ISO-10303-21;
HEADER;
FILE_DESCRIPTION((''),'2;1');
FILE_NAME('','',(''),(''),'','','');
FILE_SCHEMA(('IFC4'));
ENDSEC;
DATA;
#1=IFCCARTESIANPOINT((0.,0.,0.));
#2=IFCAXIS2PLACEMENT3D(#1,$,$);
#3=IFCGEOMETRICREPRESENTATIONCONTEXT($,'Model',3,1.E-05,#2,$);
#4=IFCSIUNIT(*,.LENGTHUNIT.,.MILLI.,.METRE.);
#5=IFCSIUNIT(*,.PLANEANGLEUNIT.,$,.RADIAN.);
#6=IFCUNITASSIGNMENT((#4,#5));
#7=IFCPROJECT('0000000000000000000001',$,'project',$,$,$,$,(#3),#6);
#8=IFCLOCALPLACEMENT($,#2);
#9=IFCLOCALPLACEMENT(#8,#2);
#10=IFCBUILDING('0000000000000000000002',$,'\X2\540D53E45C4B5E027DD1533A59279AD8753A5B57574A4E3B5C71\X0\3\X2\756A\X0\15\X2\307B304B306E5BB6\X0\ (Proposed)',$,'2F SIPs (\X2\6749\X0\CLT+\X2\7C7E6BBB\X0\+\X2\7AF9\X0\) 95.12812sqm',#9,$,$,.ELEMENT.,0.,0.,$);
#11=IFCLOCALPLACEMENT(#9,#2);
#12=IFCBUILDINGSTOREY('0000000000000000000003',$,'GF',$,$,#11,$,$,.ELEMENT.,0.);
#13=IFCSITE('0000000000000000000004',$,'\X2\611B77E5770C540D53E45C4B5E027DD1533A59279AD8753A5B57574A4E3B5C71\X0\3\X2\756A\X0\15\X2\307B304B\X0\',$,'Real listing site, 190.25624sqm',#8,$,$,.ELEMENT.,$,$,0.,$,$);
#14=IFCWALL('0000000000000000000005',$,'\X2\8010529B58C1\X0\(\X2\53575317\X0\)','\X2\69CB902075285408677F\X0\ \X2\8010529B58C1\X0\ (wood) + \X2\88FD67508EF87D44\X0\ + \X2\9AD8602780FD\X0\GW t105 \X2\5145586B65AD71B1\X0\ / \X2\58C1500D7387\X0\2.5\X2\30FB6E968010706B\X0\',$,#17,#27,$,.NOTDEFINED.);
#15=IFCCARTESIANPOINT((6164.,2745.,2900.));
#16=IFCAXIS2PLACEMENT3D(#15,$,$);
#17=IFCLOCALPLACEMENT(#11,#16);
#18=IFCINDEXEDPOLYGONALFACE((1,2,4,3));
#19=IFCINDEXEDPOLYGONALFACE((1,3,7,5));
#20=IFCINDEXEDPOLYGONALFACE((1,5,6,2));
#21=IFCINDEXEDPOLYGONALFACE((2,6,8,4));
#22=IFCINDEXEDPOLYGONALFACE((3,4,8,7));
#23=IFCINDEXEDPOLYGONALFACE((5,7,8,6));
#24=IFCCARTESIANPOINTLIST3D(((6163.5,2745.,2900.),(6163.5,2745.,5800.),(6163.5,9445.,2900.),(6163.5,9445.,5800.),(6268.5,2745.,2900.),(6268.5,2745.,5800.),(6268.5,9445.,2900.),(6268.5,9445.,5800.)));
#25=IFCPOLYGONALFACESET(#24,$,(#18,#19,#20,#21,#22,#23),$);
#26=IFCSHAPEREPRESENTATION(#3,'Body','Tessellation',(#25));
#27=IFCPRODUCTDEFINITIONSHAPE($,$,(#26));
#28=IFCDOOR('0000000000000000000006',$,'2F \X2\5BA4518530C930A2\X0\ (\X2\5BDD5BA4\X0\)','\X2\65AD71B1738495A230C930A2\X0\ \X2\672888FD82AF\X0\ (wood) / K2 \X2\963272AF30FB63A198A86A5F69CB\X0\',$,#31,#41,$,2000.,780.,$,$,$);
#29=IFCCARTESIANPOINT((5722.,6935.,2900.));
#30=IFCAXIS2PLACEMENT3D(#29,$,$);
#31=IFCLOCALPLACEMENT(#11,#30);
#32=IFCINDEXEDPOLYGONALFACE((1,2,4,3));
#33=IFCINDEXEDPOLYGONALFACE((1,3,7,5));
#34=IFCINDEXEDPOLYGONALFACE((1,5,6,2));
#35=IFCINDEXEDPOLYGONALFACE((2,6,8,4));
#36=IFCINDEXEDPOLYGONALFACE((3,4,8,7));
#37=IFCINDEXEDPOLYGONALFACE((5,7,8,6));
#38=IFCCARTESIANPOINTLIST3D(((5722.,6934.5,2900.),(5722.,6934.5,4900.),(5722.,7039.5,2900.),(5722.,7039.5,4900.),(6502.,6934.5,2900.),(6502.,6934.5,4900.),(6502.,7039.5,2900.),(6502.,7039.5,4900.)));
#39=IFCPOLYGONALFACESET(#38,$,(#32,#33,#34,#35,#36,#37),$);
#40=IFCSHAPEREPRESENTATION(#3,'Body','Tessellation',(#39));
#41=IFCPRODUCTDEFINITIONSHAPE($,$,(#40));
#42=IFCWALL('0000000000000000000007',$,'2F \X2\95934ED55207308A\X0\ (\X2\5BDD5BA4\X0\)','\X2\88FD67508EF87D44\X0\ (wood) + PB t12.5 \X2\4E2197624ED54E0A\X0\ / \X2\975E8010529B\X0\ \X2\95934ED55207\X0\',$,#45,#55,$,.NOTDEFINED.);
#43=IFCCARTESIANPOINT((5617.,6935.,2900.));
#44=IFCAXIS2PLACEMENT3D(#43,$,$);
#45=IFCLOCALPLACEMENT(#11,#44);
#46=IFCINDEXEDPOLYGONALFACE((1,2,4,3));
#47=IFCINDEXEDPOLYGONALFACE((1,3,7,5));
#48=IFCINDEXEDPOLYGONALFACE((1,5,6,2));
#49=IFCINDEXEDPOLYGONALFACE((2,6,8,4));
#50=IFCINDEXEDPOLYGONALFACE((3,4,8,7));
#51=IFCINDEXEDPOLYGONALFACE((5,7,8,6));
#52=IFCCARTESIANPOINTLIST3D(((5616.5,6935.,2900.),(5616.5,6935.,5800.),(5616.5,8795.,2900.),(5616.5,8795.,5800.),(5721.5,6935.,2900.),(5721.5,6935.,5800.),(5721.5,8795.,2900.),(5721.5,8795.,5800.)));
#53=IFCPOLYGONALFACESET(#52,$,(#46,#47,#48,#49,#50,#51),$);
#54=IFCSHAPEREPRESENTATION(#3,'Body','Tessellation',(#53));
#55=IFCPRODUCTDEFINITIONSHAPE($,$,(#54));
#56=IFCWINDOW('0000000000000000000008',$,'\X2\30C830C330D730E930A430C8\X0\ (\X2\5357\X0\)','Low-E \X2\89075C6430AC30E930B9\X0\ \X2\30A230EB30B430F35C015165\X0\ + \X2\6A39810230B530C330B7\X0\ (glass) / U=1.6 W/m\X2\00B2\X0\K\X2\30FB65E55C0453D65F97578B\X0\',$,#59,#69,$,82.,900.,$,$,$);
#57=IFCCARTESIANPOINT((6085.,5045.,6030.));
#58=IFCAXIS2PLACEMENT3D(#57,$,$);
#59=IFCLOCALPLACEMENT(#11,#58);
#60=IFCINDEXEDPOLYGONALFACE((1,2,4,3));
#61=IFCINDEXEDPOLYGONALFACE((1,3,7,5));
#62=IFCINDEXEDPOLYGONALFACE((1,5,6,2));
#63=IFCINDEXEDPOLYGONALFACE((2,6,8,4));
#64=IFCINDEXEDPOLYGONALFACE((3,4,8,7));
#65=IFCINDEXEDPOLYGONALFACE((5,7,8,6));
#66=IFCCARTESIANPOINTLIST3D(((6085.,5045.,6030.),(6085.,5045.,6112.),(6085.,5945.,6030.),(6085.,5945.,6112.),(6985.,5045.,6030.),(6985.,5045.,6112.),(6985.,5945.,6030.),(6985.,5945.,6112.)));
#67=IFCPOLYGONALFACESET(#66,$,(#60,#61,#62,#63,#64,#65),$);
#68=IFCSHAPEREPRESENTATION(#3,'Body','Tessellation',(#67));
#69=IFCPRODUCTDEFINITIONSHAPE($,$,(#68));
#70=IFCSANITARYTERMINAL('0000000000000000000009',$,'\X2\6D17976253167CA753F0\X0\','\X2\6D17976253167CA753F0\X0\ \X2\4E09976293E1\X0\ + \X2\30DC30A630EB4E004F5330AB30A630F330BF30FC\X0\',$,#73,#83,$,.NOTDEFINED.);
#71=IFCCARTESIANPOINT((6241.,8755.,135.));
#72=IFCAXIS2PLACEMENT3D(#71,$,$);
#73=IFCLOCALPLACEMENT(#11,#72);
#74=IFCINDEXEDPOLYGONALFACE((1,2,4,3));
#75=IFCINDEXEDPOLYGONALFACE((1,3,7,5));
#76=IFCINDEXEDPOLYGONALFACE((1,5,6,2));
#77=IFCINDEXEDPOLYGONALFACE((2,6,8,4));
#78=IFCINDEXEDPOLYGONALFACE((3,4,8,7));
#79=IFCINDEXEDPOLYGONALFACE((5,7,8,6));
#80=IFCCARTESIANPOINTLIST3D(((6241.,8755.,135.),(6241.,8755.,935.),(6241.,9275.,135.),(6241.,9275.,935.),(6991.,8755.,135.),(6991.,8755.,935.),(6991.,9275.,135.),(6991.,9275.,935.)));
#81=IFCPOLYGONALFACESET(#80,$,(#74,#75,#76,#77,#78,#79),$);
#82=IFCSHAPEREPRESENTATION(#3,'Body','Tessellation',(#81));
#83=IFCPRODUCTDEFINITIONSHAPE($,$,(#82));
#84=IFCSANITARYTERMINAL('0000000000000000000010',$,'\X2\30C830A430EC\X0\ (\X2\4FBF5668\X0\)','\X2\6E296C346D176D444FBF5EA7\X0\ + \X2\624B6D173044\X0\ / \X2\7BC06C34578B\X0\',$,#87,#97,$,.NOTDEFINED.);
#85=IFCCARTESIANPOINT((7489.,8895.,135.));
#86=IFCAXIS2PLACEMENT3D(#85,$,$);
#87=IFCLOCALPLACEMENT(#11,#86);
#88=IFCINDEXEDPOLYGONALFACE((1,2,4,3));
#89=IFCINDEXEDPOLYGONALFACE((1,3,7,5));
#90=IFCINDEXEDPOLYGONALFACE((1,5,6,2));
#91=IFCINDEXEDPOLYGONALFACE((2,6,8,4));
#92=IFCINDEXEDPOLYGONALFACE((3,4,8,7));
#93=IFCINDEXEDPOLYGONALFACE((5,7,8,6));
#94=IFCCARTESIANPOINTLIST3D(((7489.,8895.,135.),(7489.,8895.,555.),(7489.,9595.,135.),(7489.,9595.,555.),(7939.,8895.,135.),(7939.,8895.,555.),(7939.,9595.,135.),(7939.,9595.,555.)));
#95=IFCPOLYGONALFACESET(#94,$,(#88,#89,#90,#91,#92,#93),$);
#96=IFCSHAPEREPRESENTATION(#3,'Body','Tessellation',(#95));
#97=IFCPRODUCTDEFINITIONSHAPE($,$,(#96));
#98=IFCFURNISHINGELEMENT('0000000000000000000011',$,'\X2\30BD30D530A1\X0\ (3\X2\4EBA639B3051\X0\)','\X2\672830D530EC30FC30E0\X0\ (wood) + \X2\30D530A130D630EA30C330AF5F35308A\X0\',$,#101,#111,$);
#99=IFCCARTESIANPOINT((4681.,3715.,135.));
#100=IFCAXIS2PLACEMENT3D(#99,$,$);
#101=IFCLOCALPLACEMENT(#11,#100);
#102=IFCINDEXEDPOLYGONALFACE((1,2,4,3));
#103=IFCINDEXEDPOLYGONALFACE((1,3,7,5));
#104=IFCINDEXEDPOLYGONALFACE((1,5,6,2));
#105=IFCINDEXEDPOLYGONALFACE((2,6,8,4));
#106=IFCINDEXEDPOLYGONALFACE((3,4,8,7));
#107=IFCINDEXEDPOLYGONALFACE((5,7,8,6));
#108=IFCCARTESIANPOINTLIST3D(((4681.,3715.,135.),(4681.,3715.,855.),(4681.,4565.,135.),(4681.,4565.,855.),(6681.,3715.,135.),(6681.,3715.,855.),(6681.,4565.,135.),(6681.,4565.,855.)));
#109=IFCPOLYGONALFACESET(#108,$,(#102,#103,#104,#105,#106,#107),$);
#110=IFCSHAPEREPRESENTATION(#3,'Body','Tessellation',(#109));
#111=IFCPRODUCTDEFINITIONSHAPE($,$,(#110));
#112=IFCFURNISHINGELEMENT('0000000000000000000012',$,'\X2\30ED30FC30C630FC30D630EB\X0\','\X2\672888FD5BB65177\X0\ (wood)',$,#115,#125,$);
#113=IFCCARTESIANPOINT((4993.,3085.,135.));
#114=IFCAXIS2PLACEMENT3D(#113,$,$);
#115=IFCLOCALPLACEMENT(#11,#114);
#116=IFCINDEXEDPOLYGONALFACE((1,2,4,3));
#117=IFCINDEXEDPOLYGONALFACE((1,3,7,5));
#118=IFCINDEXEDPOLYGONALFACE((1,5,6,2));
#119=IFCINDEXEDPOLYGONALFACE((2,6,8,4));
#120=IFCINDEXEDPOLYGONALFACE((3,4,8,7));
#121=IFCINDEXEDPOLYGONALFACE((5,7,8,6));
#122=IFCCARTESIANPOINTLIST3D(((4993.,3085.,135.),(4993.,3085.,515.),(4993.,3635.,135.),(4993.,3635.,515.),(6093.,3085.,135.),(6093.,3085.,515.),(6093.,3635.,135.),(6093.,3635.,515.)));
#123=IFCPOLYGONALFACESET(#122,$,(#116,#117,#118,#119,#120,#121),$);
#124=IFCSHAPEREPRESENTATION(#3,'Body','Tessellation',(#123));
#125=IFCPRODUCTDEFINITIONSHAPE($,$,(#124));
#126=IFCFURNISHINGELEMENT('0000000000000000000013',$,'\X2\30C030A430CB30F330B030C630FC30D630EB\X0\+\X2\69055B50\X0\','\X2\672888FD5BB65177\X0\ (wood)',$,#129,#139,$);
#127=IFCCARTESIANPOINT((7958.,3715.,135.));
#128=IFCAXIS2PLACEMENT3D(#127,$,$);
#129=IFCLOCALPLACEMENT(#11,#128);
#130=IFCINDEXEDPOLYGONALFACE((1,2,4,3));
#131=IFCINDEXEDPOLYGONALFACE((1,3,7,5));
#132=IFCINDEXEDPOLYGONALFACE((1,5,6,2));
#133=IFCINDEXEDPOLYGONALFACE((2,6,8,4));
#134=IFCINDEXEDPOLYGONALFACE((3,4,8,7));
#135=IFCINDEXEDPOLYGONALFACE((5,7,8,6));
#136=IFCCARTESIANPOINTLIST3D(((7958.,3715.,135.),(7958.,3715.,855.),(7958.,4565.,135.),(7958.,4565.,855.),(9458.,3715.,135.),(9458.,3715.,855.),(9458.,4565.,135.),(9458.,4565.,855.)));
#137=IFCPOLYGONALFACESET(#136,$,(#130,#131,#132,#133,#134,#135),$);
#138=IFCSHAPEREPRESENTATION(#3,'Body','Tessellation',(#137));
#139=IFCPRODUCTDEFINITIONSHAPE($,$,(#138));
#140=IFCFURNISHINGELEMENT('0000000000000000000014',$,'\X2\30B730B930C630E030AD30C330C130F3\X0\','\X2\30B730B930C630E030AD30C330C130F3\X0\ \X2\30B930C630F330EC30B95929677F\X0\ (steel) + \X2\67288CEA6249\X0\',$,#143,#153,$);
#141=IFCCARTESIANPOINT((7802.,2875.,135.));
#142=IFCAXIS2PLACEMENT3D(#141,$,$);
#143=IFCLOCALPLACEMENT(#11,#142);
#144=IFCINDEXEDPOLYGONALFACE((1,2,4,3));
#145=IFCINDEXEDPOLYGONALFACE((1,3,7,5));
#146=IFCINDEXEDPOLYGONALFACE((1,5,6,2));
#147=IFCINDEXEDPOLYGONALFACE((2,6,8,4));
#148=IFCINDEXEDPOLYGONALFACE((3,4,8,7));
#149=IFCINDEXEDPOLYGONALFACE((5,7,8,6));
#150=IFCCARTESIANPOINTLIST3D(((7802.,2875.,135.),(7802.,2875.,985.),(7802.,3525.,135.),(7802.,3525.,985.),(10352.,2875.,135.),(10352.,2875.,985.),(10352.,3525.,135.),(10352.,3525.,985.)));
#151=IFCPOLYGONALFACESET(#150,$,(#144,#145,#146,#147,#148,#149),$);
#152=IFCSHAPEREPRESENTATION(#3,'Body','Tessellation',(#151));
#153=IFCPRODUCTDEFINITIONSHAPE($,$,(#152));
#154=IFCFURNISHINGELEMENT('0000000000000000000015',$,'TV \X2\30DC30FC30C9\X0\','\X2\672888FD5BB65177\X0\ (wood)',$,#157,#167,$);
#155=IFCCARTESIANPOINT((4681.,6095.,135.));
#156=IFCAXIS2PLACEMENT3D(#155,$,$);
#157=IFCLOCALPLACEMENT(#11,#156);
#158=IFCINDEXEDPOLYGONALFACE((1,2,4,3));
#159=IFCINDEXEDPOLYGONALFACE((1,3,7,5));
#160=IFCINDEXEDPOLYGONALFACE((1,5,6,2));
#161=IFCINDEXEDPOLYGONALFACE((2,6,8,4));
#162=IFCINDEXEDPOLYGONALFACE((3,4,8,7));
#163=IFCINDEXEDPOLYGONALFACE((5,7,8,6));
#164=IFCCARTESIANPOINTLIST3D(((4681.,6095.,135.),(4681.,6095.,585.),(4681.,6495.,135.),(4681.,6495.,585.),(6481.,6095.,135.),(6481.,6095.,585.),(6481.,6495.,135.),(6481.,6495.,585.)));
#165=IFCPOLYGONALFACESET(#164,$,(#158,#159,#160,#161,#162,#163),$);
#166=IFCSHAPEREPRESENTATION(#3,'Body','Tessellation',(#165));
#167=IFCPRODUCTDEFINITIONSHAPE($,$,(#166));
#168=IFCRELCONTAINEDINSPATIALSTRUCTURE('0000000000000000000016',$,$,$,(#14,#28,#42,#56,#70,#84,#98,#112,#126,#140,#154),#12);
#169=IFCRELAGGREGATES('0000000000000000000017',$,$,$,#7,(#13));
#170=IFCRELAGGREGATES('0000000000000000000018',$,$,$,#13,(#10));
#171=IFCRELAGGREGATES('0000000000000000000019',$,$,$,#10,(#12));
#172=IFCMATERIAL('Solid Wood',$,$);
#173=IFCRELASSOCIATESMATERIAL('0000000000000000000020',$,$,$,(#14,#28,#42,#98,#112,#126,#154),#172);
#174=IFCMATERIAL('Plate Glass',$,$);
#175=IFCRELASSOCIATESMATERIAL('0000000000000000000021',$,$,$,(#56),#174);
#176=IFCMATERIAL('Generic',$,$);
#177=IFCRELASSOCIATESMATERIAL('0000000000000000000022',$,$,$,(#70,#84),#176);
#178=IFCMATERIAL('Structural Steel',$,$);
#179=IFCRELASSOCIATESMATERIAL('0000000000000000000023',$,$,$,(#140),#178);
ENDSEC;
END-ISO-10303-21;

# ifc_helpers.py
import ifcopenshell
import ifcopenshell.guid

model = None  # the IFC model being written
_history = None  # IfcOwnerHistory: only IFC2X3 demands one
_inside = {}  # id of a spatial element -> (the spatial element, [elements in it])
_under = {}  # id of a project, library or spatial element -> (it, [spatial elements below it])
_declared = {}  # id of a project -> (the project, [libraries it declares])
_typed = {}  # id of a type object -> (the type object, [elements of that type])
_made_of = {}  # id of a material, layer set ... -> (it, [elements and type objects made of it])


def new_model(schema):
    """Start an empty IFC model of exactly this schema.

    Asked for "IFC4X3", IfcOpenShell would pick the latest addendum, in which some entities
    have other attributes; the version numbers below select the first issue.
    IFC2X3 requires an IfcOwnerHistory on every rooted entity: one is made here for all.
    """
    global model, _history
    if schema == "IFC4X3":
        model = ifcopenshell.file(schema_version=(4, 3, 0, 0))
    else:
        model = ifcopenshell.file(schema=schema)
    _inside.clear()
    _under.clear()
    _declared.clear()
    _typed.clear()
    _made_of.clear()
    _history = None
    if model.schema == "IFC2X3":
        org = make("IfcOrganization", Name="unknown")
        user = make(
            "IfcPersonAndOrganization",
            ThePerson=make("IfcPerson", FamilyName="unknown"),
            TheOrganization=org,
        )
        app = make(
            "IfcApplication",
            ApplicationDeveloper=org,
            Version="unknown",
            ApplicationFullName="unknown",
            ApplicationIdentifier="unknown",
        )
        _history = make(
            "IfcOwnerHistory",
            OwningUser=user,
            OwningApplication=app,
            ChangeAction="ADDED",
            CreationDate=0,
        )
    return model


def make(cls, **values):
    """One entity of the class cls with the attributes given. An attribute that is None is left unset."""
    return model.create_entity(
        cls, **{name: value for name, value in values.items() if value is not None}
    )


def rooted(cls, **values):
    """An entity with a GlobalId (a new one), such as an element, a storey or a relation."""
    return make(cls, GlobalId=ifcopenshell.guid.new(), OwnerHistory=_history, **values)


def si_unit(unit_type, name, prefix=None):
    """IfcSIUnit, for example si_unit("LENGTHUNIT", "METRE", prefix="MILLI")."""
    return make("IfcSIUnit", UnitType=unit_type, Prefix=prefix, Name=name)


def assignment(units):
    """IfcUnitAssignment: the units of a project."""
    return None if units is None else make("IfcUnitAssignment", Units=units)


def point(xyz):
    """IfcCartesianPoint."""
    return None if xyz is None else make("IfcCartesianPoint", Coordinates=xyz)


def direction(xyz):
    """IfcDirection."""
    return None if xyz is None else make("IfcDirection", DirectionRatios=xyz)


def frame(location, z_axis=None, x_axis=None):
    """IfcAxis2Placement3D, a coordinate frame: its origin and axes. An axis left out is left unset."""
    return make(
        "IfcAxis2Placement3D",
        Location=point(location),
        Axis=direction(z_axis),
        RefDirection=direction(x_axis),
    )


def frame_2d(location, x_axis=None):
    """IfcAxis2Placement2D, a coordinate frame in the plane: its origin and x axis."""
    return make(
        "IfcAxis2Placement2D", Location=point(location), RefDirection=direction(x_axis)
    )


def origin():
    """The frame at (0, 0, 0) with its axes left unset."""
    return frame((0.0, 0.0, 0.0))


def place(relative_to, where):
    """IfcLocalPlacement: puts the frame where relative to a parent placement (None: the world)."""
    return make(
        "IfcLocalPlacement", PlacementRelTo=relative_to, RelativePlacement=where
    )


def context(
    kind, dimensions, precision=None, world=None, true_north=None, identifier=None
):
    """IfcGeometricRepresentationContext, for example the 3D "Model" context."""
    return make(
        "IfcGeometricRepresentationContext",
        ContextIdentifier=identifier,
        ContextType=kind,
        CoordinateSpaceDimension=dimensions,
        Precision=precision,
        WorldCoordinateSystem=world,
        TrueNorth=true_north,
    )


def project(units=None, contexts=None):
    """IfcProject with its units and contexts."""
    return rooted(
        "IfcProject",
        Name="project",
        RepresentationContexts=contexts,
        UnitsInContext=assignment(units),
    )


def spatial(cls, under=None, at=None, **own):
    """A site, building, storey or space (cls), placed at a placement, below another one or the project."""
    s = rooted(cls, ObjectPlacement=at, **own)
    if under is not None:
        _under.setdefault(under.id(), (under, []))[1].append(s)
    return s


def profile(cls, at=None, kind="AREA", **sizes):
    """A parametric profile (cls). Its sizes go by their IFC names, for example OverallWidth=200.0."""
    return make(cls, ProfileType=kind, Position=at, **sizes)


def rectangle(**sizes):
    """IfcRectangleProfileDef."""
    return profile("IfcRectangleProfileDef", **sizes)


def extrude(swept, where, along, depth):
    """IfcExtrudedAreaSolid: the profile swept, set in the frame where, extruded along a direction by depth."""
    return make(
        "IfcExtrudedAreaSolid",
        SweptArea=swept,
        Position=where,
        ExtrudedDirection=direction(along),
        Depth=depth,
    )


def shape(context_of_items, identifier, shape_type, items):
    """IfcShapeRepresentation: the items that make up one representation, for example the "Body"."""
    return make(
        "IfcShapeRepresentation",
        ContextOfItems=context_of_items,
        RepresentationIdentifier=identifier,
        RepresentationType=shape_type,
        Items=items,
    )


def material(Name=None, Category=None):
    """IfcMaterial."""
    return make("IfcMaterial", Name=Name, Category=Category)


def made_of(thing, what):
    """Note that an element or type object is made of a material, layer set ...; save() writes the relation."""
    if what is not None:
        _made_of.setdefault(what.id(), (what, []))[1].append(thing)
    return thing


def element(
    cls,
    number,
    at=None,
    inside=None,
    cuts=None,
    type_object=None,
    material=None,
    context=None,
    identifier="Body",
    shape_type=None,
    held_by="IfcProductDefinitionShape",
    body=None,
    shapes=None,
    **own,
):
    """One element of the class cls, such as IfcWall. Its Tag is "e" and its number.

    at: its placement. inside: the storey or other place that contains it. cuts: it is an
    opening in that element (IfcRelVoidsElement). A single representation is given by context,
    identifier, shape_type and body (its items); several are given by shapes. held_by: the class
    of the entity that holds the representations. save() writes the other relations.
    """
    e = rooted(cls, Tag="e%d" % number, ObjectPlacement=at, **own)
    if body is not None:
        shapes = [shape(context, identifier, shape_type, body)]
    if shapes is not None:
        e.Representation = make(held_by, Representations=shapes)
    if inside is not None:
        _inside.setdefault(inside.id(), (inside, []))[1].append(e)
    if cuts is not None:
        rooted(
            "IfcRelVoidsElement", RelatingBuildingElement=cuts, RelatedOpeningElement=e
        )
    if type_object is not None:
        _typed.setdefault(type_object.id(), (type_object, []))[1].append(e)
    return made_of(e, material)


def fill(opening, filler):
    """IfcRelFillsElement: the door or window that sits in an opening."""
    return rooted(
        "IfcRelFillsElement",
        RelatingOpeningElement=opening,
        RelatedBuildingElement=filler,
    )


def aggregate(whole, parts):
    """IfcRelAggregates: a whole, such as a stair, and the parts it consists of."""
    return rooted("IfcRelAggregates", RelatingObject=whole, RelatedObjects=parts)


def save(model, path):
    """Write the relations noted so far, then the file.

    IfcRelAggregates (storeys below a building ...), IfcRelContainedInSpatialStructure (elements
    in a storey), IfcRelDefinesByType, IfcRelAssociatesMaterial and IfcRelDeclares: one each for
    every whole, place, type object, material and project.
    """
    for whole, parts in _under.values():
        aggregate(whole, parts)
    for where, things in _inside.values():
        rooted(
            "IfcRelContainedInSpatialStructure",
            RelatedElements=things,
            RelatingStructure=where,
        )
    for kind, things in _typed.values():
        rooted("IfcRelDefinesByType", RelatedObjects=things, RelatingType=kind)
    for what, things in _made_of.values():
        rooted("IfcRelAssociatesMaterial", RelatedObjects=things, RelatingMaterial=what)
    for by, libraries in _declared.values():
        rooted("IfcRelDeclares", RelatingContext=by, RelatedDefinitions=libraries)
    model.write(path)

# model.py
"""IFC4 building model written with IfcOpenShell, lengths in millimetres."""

from ifc_helpers import new_model, si_unit, frame, frame_2d, origin, place, context, project, spatial, rectangle, extrude, material, element, fill, save


model = new_model("IFC4")

# Units and contexts
model_context = context("Model", 3, precision=1e-05, world=origin())
ifc_project = project(units=[si_unit("LENGTHUNIT", "METRE", prefix="MILLI"), si_unit("PLANEANGLEUNIT", "RADIAN")], contexts=[model_context])

# Site, building, storey
site_placement = place(None, origin())
site = spatial("IfcSite", under=ifc_project, at=site_placement, Name="愛知県名古屋市緑区大高町字坊主山3番15ほか", ObjectType="Real listing site, 190.25624sqm", CompositionType="ELEMENT", RefElevation=0.0)
building_placement = place(site_placement, origin())
building = spatial("IfcBuilding", under=site, at=building_placement, Name="名古屋市緑区大高町字坊主山3番15ほかの家 (Proposed)", ObjectType="2F SIPs (杉CLT+籾殻+竹) 95.12812sqm", CompositionType="ELEMENT", ElevationOfRefHeight=0.0, ElevationOfTerrain=0.0)
storey_placement = place(building_placement, origin())
storey = spatial("IfcBuildingStorey", under=building, at=storey_placement, Name="GF", CompositionType="ELEMENT", Elevation=0.0)

# Shared definitions
ifc_material_1 = material(Name="Solid Wood")

# Wall, opening, door
wall_1_placement = place(storey_placement, frame((6164.0, 2745.0, 2900.0)))
wall_1 = element("IfcWall", 1, at=wall_1_placement, inside=storey, material=ifc_material_1, Name="耐力壁(南北)", Description="構造用合板 耐力壁 (wood) + 製材軸組 + 高性能GW t105 充填断熱 / 壁倍率2.5・準耐火", PredefinedType="NOTDEFINED", context=model_context, shape_type="SweptSolid", body=[
    extrude(rectangle(XDim=105.0, YDim=6700.0, at=frame_2d((52.0, 3350.0))), frame((6164.0, 2745.0, 2900.0)), (0.0, 0.0, 1.0), 2900.0),
])
opening_1_placement = place(storey_placement, frame((5722.0, 6935.0, 2900.0)))
opening_1 = element("IfcOpeningElement", 2, at=opening_1_placement, cuts=wall_1, PredefinedType="NOTDEFINED", context=model_context, shape_type="SweptSolid", body=[
    extrude(rectangle(XDim=780.0, YDim=105.0, at=frame_2d((390.0, 52.0))), frame((5722.0, 6935.0, 2900.0)), (0.0, 0.0, 1.0), 2000.0),
])
door_1_placement = place(storey_placement, frame((5722.0, 6935.0, 2900.0)))
door_1 = element("IfcDoor", 3, at=door_1_placement, inside=storey, material=ifc_material_1, Name="2F 室内ドア (寝室)", Description="断熱玄関ドア 木製芯 (wood) / K2 防犯・採風機構", OverallHeight=2000.0, OverallWidth=780.0, context=model_context, shape_type="SweptSolid", body=[
    extrude(rectangle(XDim=780.0, YDim=105.0, at=frame_2d((390.0, 52.0))), frame((5722.0, 6935.0, 2900.0)), (0.0, 0.0, 1.0), 2000.0),
])
fill(opening_1, door_1)

# Wall
wall_2_placement = place(storey_placement, frame((5617.0, 6935.0, 2900.0)))
element("IfcWall", 4, at=wall_2_placement, inside=storey, material=ifc_material_1, Name="2F 間仕切り (寝室)", Description="製材軸組 (wood) + PB t12.5 両面仕上 / 非耐力 間仕切", PredefinedType="NOTDEFINED", context=model_context, shape_type="SweptSolid", body=[
    extrude(rectangle(XDim=105.0, YDim=1860.0, at=frame_2d((52.0, 930.0))), frame((5617.0, 6935.0, 2900.0)), (0.0, 0.0, 1.0), 2900.0),
])

# Window
ifc_material_2 = material(Name="Plate Glass")
window_placement = place(storey_placement, frame((6085.0, 5045.0, 6030.0)))
element("IfcWindow", 5, at=window_placement, inside=storey, material=ifc_material_2, Name="トップライト (南)", Description="Low-E 複層ガラス アルゴン封入 + 樹脂サッシ (glass) / U=1.6 W/m²K・日射取得型", OverallHeight=82.0, OverallWidth=900.0, context=model_context, shape_type="SweptSolid", body=[
    extrude(rectangle(XDim=900.0, YDim=900.0, at=frame_2d((450.0, 450.0))), frame((6085.0, 5045.0, 6030.0)), (0.0, 0.0, 1.0), 82.0),
])

# Sanitary terminals
ifc_material_3 = material(Name="Generic")
sanitary_terminal_1_placement = place(storey_placement, frame((6241.0, 8755.0, 135.0)))
element("IfcSanitaryTerminal", 6, at=sanitary_terminal_1_placement, inside=storey, material=ifc_material_3, Name="洗面化粧台", Description="洗面化粧台 三面鏡 + ボウル一体カウンター", PredefinedType="NOTDEFINED", context=model_context, shape_type="SweptSolid", body=[
    extrude(rectangle(XDim=750.0, YDim=520.0, at=frame_2d((375.0, 260.0))), frame((6241.0, 8755.0, 135.0)), (0.0, 0.0, 1.0), 800.0),
])
sanitary_terminal_2_placement = place(storey_placement, frame((7489.0, 8895.0, 135.0)))
element("IfcSanitaryTerminal", 7, at=sanitary_terminal_2_placement, inside=storey, material=ifc_material_3, Name="トイレ (便器)", Description="温水洗浄便座 + 手洗い / 節水型", PredefinedType="NOTDEFINED", context=model_context, shape_type="SweptSolid", body=[
    extrude(rectangle(XDim=450.0, YDim=700.0, at=frame_2d((225.0, 350.0))), frame((7489.0, 8895.0, 135.0)), (0.0, 0.0, 1.0), 420.0),
])

# Furnishing elements
furnishing_1_placement = place(storey_placement, frame((4681.0, 3715.0, 135.0)))
element("IfcFurnishingElement", 8, at=furnishing_1_placement, inside=storey, material=ifc_material_1, Name="ソファ (3人掛け)", Description="木フレーム (wood) + ファブリック張り", context=model_context, shape_type="SweptSolid", body=[
    extrude(rectangle(XDim=2000.0, YDim=850.0, at=frame_2d((1000.0, 425.0))), frame((4681.0, 3715.0, 135.0)), (0.0, 0.0, 1.0), 720.0),
])
furnishing_2_placement = place(storey_placement, frame((4993.0, 3085.0, 135.0)))
element("IfcFurnishingElement", 9, at=furnishing_2_placement, inside=storey, material=ifc_material_1, Name="ローテーブル", Description="木製家具 (wood)", context=model_context, shape_type="SweptSolid", body=[
    extrude(rectangle(XDim=1100.0, YDim=550.0, at=frame_2d((550.0, 275.0))), frame((4993.0, 3085.0, 135.0)), (0.0, 0.0, 1.0), 380.0),
])
furnishing_3_placement = place(storey_placement, frame((7958.0, 3715.0, 135.0)))
element("IfcFurnishingElement", 10, at=furnishing_3_placement, inside=storey, material=ifc_material_1, Name="ダイニングテーブル+椅子", Description="木製家具 (wood)", context=model_context, shape_type="SweptSolid", body=[
    extrude(rectangle(XDim=1500.0, YDim=850.0, at=frame_2d((750.0, 425.0))), frame((7958.0, 3715.0, 135.0)), (0.0, 0.0, 1.0), 720.0),
])
ifc_material_4 = material(Name="Structural Steel")
furnishing_4_placement = place(storey_placement, frame((7802.0, 2875.0, 135.0)))
element("IfcFurnishingElement", 11, at=furnishing_4_placement, inside=storey, material=ifc_material_4, Name="システムキッチン", Description="システムキッチン ステンレス天板 (steel) + 木質扉", context=model_context, shape_type="SweptSolid", body=[
    extrude(rectangle(XDim=2550.0, YDim=650.0, at=frame_2d((1275.0, 325.0))), frame((7802.0, 2875.0, 135.0)), (0.0, 0.0, 1.0), 850.0),
])
furnishing_5_placement = place(storey_placement, frame((4681.0, 6095.0, 135.0)))
element("IfcFurnishingElement", 12, at=furnishing_5_placement, inside=storey, material=ifc_material_1, Name="TV ボード", Description="木製家具 (wood)", context=model_context, shape_type="SweptSolid", body=[
    extrude(rectangle(XDim=1800.0, YDim=400.0, at=frame_2d((900.0, 200.0))), frame((4681.0, 6095.0, 135.0)), (0.0, 0.0, 1.0), 450.0),
])

save(model, "model.ifc")
